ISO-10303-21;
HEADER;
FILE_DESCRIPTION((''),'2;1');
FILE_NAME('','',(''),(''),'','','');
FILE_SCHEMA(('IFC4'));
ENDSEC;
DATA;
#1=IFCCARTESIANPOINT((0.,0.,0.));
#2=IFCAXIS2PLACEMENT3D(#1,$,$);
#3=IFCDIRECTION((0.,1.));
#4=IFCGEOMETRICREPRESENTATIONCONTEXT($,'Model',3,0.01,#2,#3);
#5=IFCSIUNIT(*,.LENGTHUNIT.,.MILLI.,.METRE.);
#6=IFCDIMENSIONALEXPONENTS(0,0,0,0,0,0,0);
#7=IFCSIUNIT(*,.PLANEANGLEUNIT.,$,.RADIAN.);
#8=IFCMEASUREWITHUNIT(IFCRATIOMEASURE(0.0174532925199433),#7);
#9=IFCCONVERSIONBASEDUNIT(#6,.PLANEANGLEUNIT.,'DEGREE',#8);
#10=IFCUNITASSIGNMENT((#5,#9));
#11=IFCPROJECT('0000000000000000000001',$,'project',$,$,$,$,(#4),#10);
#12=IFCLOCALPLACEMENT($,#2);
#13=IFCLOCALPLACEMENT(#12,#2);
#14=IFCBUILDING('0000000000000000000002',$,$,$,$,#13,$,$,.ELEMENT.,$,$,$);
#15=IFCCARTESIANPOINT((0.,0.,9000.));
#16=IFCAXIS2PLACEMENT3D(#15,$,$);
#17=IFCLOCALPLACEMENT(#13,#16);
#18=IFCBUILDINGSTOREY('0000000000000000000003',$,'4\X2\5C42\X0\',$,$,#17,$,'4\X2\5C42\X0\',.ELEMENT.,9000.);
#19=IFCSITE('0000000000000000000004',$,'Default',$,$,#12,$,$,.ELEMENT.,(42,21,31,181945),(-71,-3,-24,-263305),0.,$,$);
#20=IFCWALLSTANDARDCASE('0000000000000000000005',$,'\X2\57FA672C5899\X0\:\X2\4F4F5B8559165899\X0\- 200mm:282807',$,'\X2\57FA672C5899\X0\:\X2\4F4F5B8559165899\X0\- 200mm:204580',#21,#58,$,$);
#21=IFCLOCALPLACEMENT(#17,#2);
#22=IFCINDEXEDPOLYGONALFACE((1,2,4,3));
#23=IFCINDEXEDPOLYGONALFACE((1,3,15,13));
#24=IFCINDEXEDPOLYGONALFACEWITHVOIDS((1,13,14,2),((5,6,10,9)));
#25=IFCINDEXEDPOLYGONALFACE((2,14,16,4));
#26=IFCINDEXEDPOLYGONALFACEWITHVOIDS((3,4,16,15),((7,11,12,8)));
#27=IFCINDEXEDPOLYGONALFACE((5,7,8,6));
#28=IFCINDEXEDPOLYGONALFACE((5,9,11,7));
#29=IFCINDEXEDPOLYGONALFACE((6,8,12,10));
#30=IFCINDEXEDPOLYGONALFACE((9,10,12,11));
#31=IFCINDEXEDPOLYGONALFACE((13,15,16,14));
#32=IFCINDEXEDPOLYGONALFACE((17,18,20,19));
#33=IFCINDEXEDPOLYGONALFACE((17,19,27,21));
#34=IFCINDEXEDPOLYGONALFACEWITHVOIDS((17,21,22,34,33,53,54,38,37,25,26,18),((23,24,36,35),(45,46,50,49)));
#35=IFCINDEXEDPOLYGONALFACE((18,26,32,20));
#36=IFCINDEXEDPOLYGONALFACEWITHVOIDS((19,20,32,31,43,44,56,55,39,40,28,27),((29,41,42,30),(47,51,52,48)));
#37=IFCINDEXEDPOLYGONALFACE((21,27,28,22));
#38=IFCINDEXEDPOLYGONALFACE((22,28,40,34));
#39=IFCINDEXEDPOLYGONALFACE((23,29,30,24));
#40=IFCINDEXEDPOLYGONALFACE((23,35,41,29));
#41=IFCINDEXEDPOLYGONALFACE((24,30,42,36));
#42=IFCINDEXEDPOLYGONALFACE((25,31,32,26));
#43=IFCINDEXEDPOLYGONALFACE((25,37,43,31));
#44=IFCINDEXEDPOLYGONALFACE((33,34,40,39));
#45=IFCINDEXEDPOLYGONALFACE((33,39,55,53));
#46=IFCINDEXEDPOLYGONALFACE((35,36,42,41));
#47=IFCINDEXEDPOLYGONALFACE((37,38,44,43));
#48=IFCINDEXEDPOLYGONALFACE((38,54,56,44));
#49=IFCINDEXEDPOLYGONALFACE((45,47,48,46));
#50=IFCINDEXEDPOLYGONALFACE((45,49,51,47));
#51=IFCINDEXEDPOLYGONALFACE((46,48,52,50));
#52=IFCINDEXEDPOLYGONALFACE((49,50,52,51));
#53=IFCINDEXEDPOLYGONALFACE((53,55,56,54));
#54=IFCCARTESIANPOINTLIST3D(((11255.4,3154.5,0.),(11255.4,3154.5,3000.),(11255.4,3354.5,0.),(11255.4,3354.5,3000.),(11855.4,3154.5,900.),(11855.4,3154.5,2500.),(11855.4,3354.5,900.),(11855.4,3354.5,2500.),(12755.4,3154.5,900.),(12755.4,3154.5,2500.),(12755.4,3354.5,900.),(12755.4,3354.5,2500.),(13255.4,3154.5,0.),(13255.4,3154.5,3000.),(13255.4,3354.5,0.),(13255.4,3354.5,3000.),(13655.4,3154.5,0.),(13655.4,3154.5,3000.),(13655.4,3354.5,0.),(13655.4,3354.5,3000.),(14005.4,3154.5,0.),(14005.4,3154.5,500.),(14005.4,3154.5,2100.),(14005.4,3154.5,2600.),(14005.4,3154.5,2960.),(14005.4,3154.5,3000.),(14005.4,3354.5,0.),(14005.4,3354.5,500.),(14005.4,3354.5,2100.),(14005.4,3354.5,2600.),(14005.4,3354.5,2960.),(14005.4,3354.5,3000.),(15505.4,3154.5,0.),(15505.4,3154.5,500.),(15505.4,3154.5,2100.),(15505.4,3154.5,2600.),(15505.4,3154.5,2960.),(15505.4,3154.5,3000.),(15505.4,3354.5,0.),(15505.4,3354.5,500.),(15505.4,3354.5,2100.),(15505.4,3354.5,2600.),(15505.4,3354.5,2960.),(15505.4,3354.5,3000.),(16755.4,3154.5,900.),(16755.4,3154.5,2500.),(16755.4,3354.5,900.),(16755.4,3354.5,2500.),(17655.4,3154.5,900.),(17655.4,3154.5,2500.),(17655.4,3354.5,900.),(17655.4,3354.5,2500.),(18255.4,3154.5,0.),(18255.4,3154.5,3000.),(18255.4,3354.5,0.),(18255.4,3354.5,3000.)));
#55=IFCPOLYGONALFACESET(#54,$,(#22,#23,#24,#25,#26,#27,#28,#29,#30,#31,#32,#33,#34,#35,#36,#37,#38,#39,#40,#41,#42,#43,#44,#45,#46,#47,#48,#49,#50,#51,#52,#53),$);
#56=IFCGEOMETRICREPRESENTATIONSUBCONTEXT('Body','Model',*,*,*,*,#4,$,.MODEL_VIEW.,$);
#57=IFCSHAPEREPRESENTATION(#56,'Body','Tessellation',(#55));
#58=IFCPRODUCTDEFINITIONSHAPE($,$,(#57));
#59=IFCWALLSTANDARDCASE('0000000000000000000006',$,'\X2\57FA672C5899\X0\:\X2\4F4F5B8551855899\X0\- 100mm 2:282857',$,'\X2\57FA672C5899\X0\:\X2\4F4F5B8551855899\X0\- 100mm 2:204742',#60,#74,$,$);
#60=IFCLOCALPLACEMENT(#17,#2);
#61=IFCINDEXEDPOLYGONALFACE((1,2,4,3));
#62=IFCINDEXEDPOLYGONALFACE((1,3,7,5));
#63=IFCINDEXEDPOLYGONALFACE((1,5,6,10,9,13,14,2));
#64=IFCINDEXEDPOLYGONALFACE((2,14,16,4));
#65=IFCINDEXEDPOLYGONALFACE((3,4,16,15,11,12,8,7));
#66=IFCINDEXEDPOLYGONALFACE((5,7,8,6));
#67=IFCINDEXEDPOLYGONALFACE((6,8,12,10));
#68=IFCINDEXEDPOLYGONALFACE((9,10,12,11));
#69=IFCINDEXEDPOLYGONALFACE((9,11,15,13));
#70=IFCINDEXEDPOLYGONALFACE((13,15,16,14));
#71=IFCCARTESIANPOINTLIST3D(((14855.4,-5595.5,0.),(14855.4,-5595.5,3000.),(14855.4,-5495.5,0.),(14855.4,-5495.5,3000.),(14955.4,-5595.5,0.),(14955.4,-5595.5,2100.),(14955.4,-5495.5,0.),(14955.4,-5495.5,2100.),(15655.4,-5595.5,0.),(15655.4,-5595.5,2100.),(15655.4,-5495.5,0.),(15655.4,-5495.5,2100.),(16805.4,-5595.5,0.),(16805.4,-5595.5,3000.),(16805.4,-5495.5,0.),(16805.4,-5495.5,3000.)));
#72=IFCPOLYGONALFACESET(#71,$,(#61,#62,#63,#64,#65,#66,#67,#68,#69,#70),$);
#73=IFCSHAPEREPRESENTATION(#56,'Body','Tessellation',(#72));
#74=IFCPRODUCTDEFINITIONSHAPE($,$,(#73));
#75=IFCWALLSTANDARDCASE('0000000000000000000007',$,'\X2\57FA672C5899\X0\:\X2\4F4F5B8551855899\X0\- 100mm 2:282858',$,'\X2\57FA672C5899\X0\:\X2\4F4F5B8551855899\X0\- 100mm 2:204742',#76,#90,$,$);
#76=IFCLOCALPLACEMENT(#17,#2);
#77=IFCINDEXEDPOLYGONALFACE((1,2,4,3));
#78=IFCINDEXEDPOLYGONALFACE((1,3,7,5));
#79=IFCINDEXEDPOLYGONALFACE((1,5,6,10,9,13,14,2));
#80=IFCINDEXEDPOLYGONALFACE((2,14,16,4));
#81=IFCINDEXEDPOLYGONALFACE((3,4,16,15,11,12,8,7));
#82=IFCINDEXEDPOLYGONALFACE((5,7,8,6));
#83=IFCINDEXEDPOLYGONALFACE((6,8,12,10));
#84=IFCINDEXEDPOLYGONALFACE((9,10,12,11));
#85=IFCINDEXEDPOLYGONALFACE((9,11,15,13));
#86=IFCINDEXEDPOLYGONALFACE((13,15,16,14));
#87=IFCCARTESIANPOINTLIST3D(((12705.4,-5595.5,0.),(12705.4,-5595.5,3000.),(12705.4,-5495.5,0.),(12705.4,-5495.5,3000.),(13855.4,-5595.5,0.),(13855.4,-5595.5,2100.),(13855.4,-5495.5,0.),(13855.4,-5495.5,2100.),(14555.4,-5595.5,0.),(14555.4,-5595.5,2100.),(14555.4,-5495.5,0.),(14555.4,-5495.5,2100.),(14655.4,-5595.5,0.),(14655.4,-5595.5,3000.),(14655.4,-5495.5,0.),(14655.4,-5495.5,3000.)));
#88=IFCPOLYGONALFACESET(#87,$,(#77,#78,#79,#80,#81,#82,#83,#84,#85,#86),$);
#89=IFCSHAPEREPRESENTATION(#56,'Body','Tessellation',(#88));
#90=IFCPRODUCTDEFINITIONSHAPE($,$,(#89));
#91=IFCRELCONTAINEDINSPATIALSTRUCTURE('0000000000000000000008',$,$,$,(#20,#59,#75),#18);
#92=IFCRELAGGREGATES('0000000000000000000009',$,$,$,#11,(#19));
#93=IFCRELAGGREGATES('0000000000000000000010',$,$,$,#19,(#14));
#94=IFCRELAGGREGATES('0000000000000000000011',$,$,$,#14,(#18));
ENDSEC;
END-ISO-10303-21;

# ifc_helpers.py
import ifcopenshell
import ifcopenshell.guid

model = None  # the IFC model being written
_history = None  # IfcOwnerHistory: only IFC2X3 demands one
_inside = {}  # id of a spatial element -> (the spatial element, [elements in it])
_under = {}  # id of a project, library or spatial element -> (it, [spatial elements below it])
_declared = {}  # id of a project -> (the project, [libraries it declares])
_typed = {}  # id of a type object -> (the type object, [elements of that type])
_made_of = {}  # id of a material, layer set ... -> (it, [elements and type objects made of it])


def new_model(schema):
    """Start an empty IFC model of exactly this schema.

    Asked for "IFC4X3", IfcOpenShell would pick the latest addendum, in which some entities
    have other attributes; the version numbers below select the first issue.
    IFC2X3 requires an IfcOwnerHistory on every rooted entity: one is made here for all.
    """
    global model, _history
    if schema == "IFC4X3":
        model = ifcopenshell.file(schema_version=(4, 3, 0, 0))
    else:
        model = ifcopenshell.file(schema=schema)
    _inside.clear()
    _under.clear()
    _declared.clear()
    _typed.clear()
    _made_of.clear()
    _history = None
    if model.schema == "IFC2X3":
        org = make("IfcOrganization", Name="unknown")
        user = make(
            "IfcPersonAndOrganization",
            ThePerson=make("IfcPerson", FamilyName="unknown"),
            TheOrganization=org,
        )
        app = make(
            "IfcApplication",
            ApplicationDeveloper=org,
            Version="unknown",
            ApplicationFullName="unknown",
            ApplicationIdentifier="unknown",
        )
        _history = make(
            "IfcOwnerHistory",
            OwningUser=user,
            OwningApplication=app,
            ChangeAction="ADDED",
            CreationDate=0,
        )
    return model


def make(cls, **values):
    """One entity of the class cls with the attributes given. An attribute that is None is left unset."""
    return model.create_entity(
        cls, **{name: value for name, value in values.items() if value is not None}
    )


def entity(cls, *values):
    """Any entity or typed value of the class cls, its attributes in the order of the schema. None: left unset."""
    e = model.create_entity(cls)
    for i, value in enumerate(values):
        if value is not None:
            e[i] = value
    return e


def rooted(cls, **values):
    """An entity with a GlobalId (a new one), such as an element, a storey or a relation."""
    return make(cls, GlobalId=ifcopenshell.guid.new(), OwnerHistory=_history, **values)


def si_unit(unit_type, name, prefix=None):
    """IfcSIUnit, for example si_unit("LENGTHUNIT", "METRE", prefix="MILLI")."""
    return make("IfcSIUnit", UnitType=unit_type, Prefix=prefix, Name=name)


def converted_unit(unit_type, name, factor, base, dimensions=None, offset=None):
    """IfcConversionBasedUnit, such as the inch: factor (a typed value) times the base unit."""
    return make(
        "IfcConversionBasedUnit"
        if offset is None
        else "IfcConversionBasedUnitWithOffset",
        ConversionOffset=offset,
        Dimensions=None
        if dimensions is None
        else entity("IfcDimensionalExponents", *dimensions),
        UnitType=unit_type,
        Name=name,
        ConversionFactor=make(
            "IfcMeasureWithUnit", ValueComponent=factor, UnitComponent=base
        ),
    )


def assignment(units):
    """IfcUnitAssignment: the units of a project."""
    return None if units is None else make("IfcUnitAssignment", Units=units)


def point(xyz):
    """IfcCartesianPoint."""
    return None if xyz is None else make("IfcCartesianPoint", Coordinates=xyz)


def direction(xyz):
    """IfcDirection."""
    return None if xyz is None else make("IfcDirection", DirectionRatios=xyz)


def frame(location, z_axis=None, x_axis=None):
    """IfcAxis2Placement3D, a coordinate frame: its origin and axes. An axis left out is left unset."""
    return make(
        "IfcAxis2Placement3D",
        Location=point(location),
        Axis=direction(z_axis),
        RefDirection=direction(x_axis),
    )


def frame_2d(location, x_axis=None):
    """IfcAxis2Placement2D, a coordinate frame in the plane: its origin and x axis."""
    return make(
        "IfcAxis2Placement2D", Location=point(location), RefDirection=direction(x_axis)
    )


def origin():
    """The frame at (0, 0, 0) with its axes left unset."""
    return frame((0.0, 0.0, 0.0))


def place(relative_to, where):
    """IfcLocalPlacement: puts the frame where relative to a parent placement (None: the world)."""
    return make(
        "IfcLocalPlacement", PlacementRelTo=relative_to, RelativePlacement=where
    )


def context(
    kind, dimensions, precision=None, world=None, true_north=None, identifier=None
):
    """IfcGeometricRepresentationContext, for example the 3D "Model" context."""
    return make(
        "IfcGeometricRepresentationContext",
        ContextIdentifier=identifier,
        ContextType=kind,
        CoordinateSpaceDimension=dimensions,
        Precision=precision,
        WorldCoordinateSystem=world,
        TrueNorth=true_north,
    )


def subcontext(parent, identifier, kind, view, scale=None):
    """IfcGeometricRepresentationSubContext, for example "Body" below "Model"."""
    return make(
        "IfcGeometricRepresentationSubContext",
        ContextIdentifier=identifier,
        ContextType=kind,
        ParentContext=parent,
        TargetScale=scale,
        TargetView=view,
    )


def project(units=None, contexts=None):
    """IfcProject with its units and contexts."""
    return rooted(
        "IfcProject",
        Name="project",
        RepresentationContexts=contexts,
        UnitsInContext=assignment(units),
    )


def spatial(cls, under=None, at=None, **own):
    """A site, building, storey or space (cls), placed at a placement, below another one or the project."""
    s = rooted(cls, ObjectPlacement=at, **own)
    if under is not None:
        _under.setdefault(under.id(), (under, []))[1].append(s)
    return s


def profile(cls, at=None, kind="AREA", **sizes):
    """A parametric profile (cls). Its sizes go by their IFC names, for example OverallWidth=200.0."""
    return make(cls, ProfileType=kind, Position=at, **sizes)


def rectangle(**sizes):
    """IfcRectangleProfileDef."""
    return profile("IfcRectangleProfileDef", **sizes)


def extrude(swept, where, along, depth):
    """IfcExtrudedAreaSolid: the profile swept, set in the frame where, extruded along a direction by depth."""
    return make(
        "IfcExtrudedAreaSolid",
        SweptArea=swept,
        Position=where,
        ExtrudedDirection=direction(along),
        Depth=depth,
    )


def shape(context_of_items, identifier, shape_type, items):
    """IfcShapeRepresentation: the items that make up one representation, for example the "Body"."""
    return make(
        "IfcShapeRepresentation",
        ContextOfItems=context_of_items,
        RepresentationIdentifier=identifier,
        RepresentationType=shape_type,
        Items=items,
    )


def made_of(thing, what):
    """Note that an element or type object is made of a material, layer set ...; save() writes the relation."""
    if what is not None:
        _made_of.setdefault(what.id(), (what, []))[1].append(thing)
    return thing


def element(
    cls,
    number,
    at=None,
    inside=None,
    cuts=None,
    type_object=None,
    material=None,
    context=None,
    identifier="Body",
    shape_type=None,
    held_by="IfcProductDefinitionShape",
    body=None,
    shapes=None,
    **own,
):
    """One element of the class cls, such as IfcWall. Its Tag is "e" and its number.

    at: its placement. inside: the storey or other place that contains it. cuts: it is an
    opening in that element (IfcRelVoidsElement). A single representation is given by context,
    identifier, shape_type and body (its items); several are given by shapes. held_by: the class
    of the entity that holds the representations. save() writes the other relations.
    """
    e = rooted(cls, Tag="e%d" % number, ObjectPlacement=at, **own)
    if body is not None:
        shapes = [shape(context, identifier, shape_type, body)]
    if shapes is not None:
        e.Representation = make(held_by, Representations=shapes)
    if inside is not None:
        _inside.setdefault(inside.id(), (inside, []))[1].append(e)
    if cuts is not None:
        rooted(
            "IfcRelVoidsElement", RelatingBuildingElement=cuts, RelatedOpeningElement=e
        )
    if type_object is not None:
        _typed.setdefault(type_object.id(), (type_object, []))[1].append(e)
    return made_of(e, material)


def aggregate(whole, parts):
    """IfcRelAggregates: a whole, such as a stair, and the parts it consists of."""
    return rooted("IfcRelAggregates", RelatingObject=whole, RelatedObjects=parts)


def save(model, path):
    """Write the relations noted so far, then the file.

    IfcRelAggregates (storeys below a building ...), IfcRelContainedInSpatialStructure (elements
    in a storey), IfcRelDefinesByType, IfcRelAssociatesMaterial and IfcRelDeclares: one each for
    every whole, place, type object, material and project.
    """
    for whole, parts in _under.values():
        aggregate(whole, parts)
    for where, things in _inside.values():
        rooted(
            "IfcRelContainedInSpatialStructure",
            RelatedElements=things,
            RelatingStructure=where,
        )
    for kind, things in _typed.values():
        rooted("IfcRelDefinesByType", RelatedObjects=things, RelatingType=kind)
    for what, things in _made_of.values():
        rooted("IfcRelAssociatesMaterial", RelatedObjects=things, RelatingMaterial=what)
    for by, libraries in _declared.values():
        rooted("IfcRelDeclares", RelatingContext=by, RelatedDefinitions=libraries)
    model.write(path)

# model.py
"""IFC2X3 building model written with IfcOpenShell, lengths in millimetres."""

from ifc_helpers import new_model, entity, si_unit, converted_unit, direction, frame, frame_2d, origin, place, context, subcontext, project, spatial, rectangle, extrude, element, save


model = new_model("IFC2X3")

# Units and contexts
model_context = context("Model", 3, precision=0.01, world=origin(), true_north=direction((0.0, 1.0)))
body_context = subcontext(model_context, "Body", "Model", "MODEL_VIEW")
ifc_project = project(units=[si_unit("LENGTHUNIT", "METRE", prefix="MILLI"), converted_unit("PLANEANGLEUNIT", "DEGREE", entity("IfcRatioMeasure", 0.0174532925199433), si_unit("PLANEANGLEUNIT", "RADIAN"), dimensions=[0, 0, 0, 0, 0, 0, 0])], contexts=[model_context])

# Site, building, storey
site_placement = place(None, origin())
site = spatial("IfcSite", under=ifc_project, at=site_placement, Name="Default", CompositionType="ELEMENT", RefLatitude=(42, 21, 31, 181945), RefLongitude=(-71, -3, -24, -263305), RefElevation=0.0)
building_placement = place(site_placement, origin())
building = spatial("IfcBuilding", under=site, at=building_placement, CompositionType="ELEMENT")
storey_placement = place(building_placement, frame((0.0, 0.0, 9000.0)))
storey = spatial("IfcBuildingStorey", under=building, at=storey_placement, Name="4层", LongName="4层", CompositionType="ELEMENT", Elevation=9000.0)

# Wall, openings
wall_1_placement = place(storey_placement, frame((18255.4, 3254.5, 0.0), z_axis=(0.0, 0.0, 1.0), x_axis=(-1.0, 0.0, 0.0)))
wall_1 = element("IfcWallStandardCase", 1, at=wall_1_placement, inside=storey, Name="基本墙:住宅外墙- 200mm:282807", ObjectType="基本墙:住宅外墙- 200mm:204580", context=body_context, shape_type="SweptSolid", body=[
    extrude(rectangle(XDim=7000.0, YDim=200.0, at=frame_2d((3500.0, 0.0), x_axis=(-1.0, 0.0))), origin(), (0.0, 0.0, 1.0), 3000.0),
])
opening_1_placement = place(wall_1_placement, origin())
element("IfcOpeningElement", 2, at=opening_1_placement, cuts=wall_1, ObjectType="Opening", context=body_context, shape_type="SweptSolid", body=[
    extrude(rectangle(XDim=500.0, YDim=1500.0, at=frame_2d((0.0, 0.0), x_axis=(0.0, 1.0))), frame((3500.0, -1424.0, 250.0), z_axis=(0.0, 1.0, 0.0), x_axis=(-1.0, 0.0, 0.0)), (0.0, 0.0, 1.0), 3048.0),
])
opening_2_placement = place(storey_placement, frame((18255.4, 3254.5, 0.0), z_axis=(0.0, 0.0, 1.0), x_axis=(-1.0, 0.0, 0.0)))
element("IfcOpeningElement", 3, at=opening_2_placement, cuts=wall_1, ObjectType="Opening", context=body_context, shape_type="SweptSolid", body=[
    extrude(rectangle(XDim=3000.0, YDim=200.0, at=frame_2d((0.0, 0.0), x_axis=(1.0, 0.0))), frame((5000.0, 0.0, 1500.0), z_axis=(-1.0, 0.0, 0.0), x_axis=(0.0, 0.0, 1.0)), (0.0, 0.0, 1.0), 400.0),
])
opening_3_placement = place(wall_1_placement, frame((4250.0, 100.0, 2960.0)))
element("IfcOpeningElement", 4, at=opening_3_placement, cuts=wall_1, ObjectType="Opening", context=body_context, shape_type="SweptSolid", body=[
    extrude(rectangle(XDim=500.0, YDim=1500.0, at=frame_2d((250.0, 750.0), x_axis=(1.0, 0.0))), frame((0.0, 0.0, 0.0), z_axis=(0.0, -1.0, 0.0), x_axis=(0.0, 0.0, 1.0)), (0.0, 0.0, 1.0), 200.0),
])
opening_4_placement = place(wall_1_placement, frame((600.0, -100.0, 900.0)))
element("IfcOpeningElement", 5, at=opening_4_placement, cuts=wall_1, ObjectType="Opening", context=body_context, shape_type="SweptSolid", body=[
    extrude(rectangle(XDim=1600.0, YDim=900.0, at=frame_2d((800.0, 450.0), x_axis=(1.0, 0.0))), frame((0.0, 0.0, 0.0), z_axis=(0.0, 1.0, 0.0), x_axis=(0.0, 0.0, 1.0)), (0.0, 0.0, 1.0), 200.0),
])
opening_5_placement = place(wall_1_placement, frame((5500.0, -100.0, 900.0)))
element("IfcOpeningElement", 6, at=opening_5_placement, cuts=wall_1, ObjectType="Opening", context=body_context, shape_type="SweptSolid", body=[
    extrude(rectangle(XDim=1600.0, YDim=900.0, at=frame_2d((800.0, 450.0), x_axis=(1.0, 0.0))), frame((0.0, 0.0, 0.0), z_axis=(0.0, 1.0, 0.0), x_axis=(0.0, 0.0, 1.0)), (0.0, 0.0, 1.0), 200.0),
])
opening_6_placement = place(wall_1_placement, frame((4250.0, 100.0, 2100.0)))
element("IfcOpeningElement", 7, at=opening_6_placement, cuts=wall_1, ObjectType="Opening", context=body_context, shape_type="SweptSolid", body=[
    extrude(rectangle(XDim=500.0, YDim=1500.0, at=frame_2d((250.0, 750.0), x_axis=(1.0, 0.0))), frame((0.0, 0.0, 0.0), z_axis=(0.0, -1.0, 0.0), x_axis=(0.0, 0.0, 1.0)), (0.0, 0.0, 1.0), 200.0),
])

# Walls, openings
wall_2_placement = place(storey_placement, frame((16805.4, -5545.5, 0.0), z_axis=(0.0, 0.0, 1.0), x_axis=(-1.0, 0.0, 0.0)))
wall_2 = element("IfcWallStandardCase", 8, at=wall_2_placement, inside=storey, Name="基本墙:住宅内墙- 100mm 2:282857", ObjectType="基本墙:住宅内墙- 100mm 2:204742", context=body_context, shape_type="SweptSolid", body=[
    extrude(rectangle(XDim=1950.0, YDim=100.0, at=frame_2d((975.0, 0.0), x_axis=(-1.0, 0.0))), origin(), (0.0, 0.0, 1.0), 3000.0),
])
opening_7_placement = place(wall_2_placement, frame((1850.0, 50.0, 0.0)))
element("IfcOpeningElement", 9, at=opening_7_placement, cuts=wall_2, ObjectType="Opening", context=body_context, shape_type="SweptSolid", body=[
    extrude(rectangle(XDim=2100.0, YDim=700.0, at=frame_2d((1050.0, 350.0), x_axis=(1.0, 0.0))), frame((0.0, 0.0, 0.0), z_axis=(0.0, -1.0, 0.0), x_axis=(0.0, 0.0, 1.0)), (0.0, 0.0, 1.0), 100.0),
])
wall_3_placement = place(storey_placement, frame((12705.4, -5545.5, 0.0)))
wall_3 = element("IfcWallStandardCase", 10, at=wall_3_placement, inside=storey, Name="基本墙:住宅内墙- 100mm 2:282858", ObjectType="基本墙:住宅内墙- 100mm 2:204742", context=body_context, shape_type="SweptSolid", body=[
    extrude(rectangle(XDim=1950.0, YDim=100.0, at=frame_2d((975.0, 0.0), x_axis=(-1.0, 0.0))), origin(), (0.0, 0.0, 1.0), 3000.0),
])
opening_8_placement = place(wall_3_placement, frame((1150.0, -50.0, 0.0)))
element("IfcOpeningElement", 11, at=opening_8_placement, cuts=wall_3, ObjectType="Opening", context=body_context, shape_type="SweptSolid", body=[
    extrude(rectangle(XDim=2100.0, YDim=700.0, at=frame_2d((1050.0, 350.0), x_axis=(1.0, 0.0))), frame((0.0, 0.0, 0.0), z_axis=(0.0, 1.0, 0.0), x_axis=(0.0, 0.0, 1.0)), (0.0, 0.0, 1.0), 100.0),
])

save(model, "model.ifc")
